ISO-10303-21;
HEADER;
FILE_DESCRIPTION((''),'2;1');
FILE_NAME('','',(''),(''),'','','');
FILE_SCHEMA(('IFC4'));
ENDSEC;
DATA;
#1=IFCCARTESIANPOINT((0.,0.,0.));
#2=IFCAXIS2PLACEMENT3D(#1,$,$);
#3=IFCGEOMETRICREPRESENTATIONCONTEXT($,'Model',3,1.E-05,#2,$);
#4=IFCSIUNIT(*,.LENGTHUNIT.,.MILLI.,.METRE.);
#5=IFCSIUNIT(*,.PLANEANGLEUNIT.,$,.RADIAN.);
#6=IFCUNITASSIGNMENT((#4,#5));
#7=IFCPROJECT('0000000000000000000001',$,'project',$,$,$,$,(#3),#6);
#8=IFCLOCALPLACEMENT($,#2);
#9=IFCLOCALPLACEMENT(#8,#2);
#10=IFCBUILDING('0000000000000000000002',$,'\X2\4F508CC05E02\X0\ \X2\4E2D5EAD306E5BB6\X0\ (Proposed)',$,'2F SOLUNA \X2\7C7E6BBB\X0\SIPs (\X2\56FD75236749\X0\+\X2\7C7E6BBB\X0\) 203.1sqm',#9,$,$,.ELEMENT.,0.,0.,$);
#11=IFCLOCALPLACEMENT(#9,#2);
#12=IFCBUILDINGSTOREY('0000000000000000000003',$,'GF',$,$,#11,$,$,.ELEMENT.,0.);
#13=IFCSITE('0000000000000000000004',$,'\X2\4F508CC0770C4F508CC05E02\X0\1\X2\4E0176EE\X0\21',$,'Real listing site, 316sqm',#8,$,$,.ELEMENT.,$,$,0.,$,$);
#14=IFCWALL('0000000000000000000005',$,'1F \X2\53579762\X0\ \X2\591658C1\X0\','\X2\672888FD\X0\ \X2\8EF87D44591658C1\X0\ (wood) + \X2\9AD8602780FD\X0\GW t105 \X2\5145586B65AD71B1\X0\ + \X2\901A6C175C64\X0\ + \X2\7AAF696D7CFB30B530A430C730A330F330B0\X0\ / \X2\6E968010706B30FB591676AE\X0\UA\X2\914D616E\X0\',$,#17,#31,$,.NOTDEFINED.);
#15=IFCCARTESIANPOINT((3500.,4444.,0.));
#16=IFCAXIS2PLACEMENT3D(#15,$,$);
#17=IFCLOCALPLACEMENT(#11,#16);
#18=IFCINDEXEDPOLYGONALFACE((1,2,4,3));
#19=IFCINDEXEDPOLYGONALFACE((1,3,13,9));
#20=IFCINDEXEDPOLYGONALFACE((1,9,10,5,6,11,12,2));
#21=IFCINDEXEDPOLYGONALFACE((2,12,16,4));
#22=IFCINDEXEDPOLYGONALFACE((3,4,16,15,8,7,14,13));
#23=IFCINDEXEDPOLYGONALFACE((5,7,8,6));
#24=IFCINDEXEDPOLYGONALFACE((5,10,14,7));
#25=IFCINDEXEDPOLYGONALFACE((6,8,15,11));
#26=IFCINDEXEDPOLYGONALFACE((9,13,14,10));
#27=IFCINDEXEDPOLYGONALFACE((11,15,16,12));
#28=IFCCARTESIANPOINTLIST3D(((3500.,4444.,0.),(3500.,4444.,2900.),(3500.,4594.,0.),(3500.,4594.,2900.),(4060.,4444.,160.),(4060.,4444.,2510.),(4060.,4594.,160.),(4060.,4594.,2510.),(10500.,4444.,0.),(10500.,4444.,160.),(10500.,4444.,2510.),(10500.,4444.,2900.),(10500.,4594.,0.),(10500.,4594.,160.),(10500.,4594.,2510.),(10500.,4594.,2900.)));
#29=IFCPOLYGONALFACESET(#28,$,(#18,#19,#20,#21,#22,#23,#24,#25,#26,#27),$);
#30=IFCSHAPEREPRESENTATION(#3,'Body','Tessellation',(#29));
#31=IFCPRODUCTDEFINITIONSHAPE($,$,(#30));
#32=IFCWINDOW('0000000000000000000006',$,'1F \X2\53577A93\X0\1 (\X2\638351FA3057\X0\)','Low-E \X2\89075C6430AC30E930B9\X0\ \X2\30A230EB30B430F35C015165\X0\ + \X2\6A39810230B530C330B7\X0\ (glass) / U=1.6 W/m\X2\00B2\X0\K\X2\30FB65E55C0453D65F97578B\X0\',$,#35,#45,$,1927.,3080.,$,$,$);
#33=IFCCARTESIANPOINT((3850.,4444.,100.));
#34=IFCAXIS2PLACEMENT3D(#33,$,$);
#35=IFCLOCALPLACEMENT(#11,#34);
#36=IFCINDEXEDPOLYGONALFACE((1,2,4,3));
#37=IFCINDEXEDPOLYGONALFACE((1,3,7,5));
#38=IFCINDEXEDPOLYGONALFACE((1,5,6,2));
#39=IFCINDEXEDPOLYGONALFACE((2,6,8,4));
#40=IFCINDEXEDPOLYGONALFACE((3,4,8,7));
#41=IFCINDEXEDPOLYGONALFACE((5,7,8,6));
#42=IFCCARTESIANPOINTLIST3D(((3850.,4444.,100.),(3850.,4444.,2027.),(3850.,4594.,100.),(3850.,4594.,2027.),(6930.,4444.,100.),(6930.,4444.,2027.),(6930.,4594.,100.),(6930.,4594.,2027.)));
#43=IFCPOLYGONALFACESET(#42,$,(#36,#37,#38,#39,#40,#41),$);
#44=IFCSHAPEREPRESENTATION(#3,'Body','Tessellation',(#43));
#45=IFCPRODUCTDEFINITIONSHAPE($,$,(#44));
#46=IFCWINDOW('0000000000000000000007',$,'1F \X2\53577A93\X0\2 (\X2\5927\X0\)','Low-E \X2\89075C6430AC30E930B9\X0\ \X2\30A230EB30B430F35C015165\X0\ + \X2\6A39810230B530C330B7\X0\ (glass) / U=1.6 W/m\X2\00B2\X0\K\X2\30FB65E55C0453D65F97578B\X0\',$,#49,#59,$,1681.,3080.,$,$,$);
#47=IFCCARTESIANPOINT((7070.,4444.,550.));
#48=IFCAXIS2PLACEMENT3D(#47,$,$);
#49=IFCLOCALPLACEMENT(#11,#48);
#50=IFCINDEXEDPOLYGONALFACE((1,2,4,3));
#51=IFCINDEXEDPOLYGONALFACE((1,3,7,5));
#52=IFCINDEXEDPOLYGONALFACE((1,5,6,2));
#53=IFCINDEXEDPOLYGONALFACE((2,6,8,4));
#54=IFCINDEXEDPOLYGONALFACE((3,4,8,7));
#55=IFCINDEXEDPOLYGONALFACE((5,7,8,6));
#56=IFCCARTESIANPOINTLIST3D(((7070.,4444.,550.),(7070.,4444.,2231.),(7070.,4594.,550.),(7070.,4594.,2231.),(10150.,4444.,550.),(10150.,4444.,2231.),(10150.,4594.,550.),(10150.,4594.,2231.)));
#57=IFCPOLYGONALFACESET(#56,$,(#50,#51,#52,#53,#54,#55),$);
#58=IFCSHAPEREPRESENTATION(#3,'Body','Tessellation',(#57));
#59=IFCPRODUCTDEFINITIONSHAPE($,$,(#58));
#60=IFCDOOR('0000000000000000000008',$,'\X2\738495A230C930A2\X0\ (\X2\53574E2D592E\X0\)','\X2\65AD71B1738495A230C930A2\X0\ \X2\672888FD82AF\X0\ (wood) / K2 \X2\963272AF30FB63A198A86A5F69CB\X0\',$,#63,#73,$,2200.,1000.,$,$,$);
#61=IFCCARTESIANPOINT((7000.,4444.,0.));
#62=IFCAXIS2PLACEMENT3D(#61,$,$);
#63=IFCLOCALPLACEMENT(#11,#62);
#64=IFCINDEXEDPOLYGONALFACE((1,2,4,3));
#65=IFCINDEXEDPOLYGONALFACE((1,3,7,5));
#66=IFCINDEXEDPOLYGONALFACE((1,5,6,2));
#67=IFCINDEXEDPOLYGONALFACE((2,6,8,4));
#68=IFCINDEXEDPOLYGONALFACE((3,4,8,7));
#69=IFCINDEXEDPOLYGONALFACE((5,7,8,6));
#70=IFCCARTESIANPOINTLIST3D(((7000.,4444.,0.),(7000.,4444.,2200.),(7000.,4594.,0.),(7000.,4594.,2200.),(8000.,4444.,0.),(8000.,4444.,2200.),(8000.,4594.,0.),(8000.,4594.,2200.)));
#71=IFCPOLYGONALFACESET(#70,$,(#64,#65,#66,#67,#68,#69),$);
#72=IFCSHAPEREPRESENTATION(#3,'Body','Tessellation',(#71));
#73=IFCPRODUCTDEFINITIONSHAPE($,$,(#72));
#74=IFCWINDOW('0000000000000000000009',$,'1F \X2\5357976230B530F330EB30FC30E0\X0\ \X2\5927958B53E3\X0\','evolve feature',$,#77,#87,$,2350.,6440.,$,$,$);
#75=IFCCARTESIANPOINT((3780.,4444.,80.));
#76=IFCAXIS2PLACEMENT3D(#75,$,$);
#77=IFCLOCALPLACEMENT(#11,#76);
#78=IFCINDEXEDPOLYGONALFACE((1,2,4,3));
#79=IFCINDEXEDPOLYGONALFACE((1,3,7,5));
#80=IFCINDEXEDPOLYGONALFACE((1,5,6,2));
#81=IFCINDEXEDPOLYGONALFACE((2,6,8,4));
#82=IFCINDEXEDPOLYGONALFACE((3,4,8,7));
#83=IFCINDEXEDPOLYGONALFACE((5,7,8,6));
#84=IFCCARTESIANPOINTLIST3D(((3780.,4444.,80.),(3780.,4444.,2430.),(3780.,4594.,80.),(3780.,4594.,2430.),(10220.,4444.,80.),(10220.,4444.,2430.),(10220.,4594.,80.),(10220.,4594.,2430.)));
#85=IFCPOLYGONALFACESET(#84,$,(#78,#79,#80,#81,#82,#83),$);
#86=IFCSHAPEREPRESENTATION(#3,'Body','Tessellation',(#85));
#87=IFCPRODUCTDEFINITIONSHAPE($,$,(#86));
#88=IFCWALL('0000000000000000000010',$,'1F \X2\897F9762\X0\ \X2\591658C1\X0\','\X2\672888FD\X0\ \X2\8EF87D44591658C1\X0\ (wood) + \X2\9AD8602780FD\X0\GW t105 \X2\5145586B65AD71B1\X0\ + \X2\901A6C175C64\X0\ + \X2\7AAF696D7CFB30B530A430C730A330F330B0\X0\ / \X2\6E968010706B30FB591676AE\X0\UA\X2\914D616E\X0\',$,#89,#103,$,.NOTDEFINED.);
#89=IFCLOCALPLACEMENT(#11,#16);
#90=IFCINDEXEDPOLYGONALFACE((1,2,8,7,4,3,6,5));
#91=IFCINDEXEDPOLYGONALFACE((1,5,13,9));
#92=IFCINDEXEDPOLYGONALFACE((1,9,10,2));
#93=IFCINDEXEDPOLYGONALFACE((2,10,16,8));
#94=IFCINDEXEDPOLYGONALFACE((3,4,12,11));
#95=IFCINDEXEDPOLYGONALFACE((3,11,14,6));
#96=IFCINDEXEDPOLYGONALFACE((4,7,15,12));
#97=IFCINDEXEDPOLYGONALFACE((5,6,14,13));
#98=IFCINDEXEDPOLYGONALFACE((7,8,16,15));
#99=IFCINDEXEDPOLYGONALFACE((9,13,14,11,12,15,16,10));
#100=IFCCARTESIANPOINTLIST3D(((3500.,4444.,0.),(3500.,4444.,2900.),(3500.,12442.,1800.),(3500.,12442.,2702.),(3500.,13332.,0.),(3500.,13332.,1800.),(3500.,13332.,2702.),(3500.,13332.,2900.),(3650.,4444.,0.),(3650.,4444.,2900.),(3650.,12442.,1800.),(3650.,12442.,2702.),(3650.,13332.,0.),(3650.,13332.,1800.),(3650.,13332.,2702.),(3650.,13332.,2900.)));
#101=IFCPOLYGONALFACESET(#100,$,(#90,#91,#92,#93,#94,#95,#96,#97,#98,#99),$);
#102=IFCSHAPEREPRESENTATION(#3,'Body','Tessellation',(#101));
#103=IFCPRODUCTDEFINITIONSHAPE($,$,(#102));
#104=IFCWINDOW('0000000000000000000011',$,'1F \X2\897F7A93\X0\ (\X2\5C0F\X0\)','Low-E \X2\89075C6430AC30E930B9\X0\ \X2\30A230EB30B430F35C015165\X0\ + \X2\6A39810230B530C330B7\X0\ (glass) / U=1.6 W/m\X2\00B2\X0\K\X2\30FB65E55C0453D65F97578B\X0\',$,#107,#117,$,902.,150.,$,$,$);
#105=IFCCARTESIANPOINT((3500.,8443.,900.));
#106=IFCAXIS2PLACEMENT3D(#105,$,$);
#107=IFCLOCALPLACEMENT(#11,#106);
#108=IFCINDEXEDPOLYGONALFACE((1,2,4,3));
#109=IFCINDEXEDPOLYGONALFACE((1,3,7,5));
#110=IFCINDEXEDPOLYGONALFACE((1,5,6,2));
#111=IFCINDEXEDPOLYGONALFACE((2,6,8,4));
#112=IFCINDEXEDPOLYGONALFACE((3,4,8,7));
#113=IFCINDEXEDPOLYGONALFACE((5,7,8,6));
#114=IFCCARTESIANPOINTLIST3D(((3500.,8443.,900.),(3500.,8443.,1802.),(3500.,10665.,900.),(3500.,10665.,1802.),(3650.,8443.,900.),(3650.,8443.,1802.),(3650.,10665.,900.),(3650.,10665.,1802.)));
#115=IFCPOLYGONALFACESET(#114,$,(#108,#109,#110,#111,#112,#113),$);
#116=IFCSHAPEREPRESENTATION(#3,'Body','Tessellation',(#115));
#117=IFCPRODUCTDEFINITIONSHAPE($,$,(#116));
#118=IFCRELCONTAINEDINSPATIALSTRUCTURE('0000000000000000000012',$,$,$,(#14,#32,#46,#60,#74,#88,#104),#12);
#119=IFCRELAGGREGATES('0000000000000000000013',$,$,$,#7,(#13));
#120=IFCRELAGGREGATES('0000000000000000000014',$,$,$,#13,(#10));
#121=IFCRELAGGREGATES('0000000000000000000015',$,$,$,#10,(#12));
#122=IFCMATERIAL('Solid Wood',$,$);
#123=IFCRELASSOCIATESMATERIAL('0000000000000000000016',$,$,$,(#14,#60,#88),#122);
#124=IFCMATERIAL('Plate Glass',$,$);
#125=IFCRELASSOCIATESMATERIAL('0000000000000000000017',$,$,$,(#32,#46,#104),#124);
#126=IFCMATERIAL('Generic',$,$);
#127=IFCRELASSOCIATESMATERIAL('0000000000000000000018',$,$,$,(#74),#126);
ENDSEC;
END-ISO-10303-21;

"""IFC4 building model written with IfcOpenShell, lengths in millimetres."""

from ifc_helpers import new_model, si_unit, frame, frame_2d, origin, place, context, project, spatial, rectangle, extrude, material, element, fill, save


model = new_model("IFC4")

# Units and contexts
model_context = context("Model", 3, precision=1e-05, world=origin())
ifc_project = project(units=[si_unit("LENGTHUNIT", "METRE", prefix="MILLI"), si_unit("PLANEANGLEUNIT", "RADIAN")], contexts=[model_context])

# Site, building, storey
site_placement = place(None, origin())
site = spatial("IfcSite", under=ifc_project, at=site_placement, Name="佐賀県佐賀市1丁目21", ObjectType="Real listing site, 316sqm", CompositionType="ELEMENT", RefElevation=0.0)
building_placement = place(site_placement, origin())
building = spatial("IfcBuilding", under=site, at=building_placement, Name="佐賀市 中庭の家 (Proposed)", ObjectType="2F SOLUNA 籾殻SIPs (国産杉+籾殻) 203.1sqm", CompositionType="ELEMENT", ElevationOfRefHeight=0.0, ElevationOfTerrain=0.0)
storey_placement = place(building_placement, origin())
storey = spatial("IfcBuildingStorey", under=building, at=storey_placement, Name="GF", CompositionType="ELEMENT", Elevation=0.0)

# Shared definitions
ifc_material_1 = material(Name="Solid Wood")
ifc_material_2 = material(Name="Generic")

# Wall, openings, windows, door
wall_1_placement = place(storey_placement, frame((3500.0, 4444.0, 0.0)))
wall_1 = element("IfcWall", 1, at=wall_1_placement, inside=storey, material=ifc_material_1, Name="1F 南面 外壁", Description="木製 軸組外壁 (wood) + 高性能GW t105 充填断熱 + 通気層 + 窯業系サイディング / 準耐火・外皮UA配慮", PredefinedType="NOTDEFINED", context=model_context, shape_type="SweptSolid", body=[
    extrude(rectangle(XDim=7000.0, YDim=150.0, at=frame_2d((3500.0, 75.0))), frame((3500.0, 4444.0, 0.0)), (0.0, 0.0, 1.0), 2900.0),
])
opening_1_placement = place(storey_placement, frame((3850.0, 4444.0, 100.0)))
opening_1 = element("IfcOpeningElement", 2, at=opening_1_placement, cuts=wall_1, PredefinedType="NOTDEFINED", context=model_context, shape_type="SweptSolid", body=[
    extrude(rectangle(XDim=3080.0, YDim=150.0, at=frame_2d((1540.0, 75.0))), frame((3850.0, 4444.0, 100.0)), (0.0, 0.0, 1.0), 1927.0),
])
opening_2_placement = place(storey_placement, frame((7070.0, 4444.0, 550.0)))
opening_2 = element("IfcOpeningElement", 3, at=opening_2_placement, cuts=wall_1, PredefinedType="NOTDEFINED", context=model_context, shape_type="SweptSolid", body=[
    extrude(rectangle(XDim=3080.0, YDim=150.0, at=frame_2d((1540.0, 75.0))), frame((7070.0, 4444.0, 550.0)), (0.0, 0.0, 1.0), 1681.0),
])
opening_3_placement = place(storey_placement, frame((7000.0, 4444.0, 0.0)))
opening_3 = element("IfcOpeningElement", 4, at=opening_3_placement, cuts=wall_1, PredefinedType="NOTDEFINED", context=model_context, shape_type="SweptSolid", body=[
    extrude(rectangle(XDim=1000.0, YDim=150.0, at=frame_2d((500.0, 75.0))), frame((7000.0, 4444.0, 0.0)), (0.0, 0.0, 1.0), 2200.0),
])
opening_4_placement = place(storey_placement, frame((3780.0, 4444.0, 80.0)))
opening_4 = element("IfcOpeningElement", 5, at=opening_4_placement, cuts=wall_1, PredefinedType="NOTDEFINED", context=model_context, shape_type="SweptSolid", body=[
    extrude(rectangle(XDim=6440.0, YDim=150.0, at=frame_2d((3220.0, 75.0))), frame((3780.0, 4444.0, 80.0)), (0.0, 0.0, 1.0), 2350.0),
])
ifc_material_3 = material(Name="Plate Glass")
window_1_placement = place(storey_placement, frame((3850.0, 4444.0, 100.0)))
window_1 = element("IfcWindow", 6, at=window_1_placement, inside=storey, material=ifc_material_3, Name="1F 南窓1 (掃出し)", Description="Low-E 複層ガラス アルゴン封入 + 樹脂サッシ (glass) / U=1.6 W/m²K・日射取得型", OverallHeight=1927.0, OverallWidth=3080.0, context=model_context, shape_type="SweptSolid", body=[
    extrude(rectangle(XDim=3080.0, YDim=150.0, at=frame_2d((1540.0, 75.0))), frame((3850.0, 4444.0, 100.0)), (0.0, 0.0, 1.0), 1927.0),
])
fill(opening_1, window_1)
window_2_placement = place(storey_placement, frame((7070.0, 4444.0, 550.0)))
window_2 = element("IfcWindow", 7, at=window_2_placement, inside=storey, material=ifc_material_3, Name="1F 南窓2 (大)", Description="Low-E 複層ガラス アルゴン封入 + 樹脂サッシ (glass) / U=1.6 W/m²K・日射取得型", OverallHeight=1681.0, OverallWidth=3080.0, context=model_context, shape_type="SweptSolid", body=[
    extrude(rectangle(XDim=3080.0, YDim=150.0, at=frame_2d((1540.0, 75.0))), frame((7070.0, 4444.0, 550.0)), (0.0, 0.0, 1.0), 1681.0),
])
fill(opening_2, window_2)
door_placement = place(storey_placement, frame((7000.0, 4444.0, 0.0)))
door = element("IfcDoor", 8, at=door_placement, inside=storey, material=ifc_material_1, Name="玄関ドア (南中央)", Description="断熱玄関ドア 木製芯 (wood) / K2 防犯・採風機構", OverallHeight=2200.0, OverallWidth=1000.0, context=model_context, shape_type="SweptSolid", body=[
    extrude(rectangle(XDim=1000.0, YDim=150.0, at=frame_2d((500.0, 75.0))), frame((7000.0, 4444.0, 0.0)), (0.0, 0.0, 1.0), 2200.0),
])
fill(opening_3, door)
window_3_placement = place(storey_placement, frame((3780.0, 4444.0, 80.0)))
window_3 = element("IfcWindow", 9, at=window_3_placement, inside=storey, material=ifc_material_2, Name="1F 南面サンルーム 大開口", Description="evolve feature", OverallHeight=2350.0, OverallWidth=6440.0, context=model_context, shape_type="SweptSolid", body=[
    extrude(rectangle(XDim=6440.0, YDim=150.0, at=frame_2d((3220.0, 75.0))), frame((3780.0, 4444.0, 80.0)), (0.0, 0.0, 1.0), 2350.0),
])
fill(opening_4, window_3)

# Wall, opening, window
wall_2_placement = place(storey_placement, frame((3500.0, 4444.0, 0.0)))
wall_2 = element("IfcWall", 10, at=wall_2_placement, inside=storey, material=ifc_material_1, Name="1F 西面 外壁", Description="木製 軸組外壁 (wood) + 高性能GW t105 充填断熱 + 通気層 + 窯業系サイディング / 準耐火・外皮UA配慮", PredefinedType="NOTDEFINED", context=model_context, shape_type="SweptSolid", body=[
    extrude(rectangle(XDim=150.0, YDim=8888.0, at=frame_2d((75.0, 4444.0))), frame((3500.0, 4444.0, 0.0)), (0.0, 0.0, 1.0), 2900.0),
])
opening_5_placement = place(storey_placement, frame((3500.0, 8443.0, 900.0)))
opening_5 = element("IfcOpeningElement", 11, at=opening_5_placement, cuts=wall_2, PredefinedType="NOTDEFINED", context=model_context, shape_type="SweptSolid", body=[
    extrude(rectangle(XDim=150.0, YDim=2222.0, at=frame_2d((75.0, 1111.0))), frame((3500.0, 8443.0, 900.0)), (0.0, 0.0, 1.0), 902.0),
])
window_4_placement = place(storey_placement, frame((3500.0, 8443.0, 900.0)))
window_4 = element("IfcWindow", 12, at=window_4_placement, inside=storey, material=ifc_material_3, Name="1F 西窓 (小)", Description="Low-E 複層ガラス アルゴン封入 + 樹脂サッシ (glass) / U=1.6 W/m²K・日射取得型", OverallHeight=902.0, OverallWidth=150.0, context=model_context, shape_type="SweptSolid", body=[
    extrude(rectangle(XDim=150.0, YDim=2222.0, at=frame_2d((75.0, 1111.0))), frame((3500.0, 8443.0, 900.0)), (0.0, 0.0, 1.0), 902.0),
])
fill(opening_5, window_4)

save(model, "model.ifc")
